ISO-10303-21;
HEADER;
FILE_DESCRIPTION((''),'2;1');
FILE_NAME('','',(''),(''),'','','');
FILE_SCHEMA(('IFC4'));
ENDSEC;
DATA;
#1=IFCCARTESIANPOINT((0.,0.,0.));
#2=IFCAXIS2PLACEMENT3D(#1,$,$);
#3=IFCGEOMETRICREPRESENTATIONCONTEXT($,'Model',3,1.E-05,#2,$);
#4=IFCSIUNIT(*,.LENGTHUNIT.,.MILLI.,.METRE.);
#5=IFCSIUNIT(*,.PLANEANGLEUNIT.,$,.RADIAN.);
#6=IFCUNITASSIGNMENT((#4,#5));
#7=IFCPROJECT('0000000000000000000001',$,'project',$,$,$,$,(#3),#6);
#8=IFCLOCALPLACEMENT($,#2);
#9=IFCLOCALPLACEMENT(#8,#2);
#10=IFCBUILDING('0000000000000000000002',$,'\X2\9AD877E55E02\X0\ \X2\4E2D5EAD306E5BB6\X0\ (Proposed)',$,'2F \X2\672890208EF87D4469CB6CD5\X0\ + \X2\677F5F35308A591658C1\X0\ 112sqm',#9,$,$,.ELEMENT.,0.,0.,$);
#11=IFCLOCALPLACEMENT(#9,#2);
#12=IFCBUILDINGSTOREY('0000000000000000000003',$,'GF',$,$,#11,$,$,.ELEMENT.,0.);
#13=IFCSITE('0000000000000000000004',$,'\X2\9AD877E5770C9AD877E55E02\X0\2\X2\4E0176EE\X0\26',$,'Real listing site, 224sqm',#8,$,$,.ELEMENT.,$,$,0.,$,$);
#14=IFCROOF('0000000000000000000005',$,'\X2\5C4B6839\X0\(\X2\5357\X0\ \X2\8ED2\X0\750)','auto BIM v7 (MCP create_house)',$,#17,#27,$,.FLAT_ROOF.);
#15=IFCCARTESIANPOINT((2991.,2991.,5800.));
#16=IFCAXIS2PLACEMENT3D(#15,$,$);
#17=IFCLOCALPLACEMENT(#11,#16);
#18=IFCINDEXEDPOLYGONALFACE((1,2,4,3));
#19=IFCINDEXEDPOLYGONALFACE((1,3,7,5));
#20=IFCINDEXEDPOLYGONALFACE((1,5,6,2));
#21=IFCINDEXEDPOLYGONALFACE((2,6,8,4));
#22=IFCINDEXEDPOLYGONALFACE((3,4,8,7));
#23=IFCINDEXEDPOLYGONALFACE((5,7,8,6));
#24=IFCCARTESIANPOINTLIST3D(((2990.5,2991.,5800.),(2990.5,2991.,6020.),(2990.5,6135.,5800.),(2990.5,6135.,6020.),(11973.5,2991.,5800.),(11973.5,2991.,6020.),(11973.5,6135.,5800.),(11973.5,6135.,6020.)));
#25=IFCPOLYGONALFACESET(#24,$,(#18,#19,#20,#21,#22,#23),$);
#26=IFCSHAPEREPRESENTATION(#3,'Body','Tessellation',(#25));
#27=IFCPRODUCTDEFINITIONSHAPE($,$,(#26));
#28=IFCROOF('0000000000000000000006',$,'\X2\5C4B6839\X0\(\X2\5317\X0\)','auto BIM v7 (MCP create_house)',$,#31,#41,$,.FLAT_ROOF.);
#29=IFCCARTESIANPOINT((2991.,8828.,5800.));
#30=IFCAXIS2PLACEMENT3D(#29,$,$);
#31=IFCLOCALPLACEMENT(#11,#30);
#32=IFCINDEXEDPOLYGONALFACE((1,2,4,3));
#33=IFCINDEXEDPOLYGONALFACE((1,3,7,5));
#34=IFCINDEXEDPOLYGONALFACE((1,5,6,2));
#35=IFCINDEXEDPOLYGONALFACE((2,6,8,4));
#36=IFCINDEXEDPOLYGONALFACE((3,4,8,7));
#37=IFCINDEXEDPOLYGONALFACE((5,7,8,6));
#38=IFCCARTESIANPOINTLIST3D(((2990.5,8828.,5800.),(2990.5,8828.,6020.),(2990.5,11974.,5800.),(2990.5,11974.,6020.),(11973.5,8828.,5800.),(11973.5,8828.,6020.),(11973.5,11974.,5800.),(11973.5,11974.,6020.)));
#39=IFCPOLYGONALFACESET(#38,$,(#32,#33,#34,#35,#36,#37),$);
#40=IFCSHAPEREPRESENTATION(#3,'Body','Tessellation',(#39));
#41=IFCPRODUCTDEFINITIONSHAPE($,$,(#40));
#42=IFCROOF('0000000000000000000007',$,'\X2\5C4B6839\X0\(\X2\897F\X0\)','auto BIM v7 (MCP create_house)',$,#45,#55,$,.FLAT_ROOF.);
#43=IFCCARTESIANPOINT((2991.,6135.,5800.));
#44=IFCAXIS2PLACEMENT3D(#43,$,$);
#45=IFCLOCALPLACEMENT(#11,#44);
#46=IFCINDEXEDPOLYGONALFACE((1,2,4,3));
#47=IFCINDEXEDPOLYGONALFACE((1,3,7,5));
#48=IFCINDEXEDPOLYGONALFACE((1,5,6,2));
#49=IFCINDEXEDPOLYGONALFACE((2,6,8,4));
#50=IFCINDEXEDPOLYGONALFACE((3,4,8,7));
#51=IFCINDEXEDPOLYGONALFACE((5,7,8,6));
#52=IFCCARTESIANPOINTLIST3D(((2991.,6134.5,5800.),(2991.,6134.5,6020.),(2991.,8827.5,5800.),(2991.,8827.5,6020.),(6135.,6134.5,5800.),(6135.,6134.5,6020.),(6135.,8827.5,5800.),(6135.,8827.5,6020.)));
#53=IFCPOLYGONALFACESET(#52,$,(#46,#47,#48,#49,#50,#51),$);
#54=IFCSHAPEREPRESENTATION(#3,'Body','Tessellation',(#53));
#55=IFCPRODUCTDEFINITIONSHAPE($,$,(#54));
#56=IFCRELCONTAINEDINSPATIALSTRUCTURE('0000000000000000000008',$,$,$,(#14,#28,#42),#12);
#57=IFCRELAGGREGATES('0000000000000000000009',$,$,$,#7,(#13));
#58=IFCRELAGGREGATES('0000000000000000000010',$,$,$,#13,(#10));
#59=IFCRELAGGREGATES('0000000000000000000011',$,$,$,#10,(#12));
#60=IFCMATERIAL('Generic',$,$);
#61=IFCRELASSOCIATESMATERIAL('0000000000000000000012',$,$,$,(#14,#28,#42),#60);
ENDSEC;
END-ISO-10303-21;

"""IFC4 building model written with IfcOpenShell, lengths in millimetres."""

from ifc_helpers import new_model, si_unit, frame, frame_2d, origin, place, context, project, spatial, rectangle, extrude, material, element, save


model = new_model("IFC4")

# Units and contexts
model_context = context("Model", 3, precision=1e-05, world=origin())
ifc_project = project(units=[si_unit("LENGTHUNIT", "METRE", prefix="MILLI"), si_unit("PLANEANGLEUNIT", "RADIAN")], contexts=[model_context])

# Site, building, storey
site_placement = place(None, origin())
site = spatial("IfcSite", under=ifc_project, at=site_placement, Name="高知県高知市2丁目26", ObjectType="Real listing site, 224sqm", CompositionType="ELEMENT", RefElevation=0.0)
building_placement = place(site_placement, origin())
building = spatial("IfcBuilding", under=site, at=building_placement, Name="高知市 中庭の家 (Proposed)", ObjectType="2F 木造軸組構法 + 板張り外壁 112sqm", CompositionType="ELEMENT", ElevationOfRefHeight=0.0, ElevationOfTerrain=0.0)
storey_placement = place(building_placement, origin())
storey = spatial("IfcBuildingStorey", under=building, at=storey_placement, Name="GF", CompositionType="ELEMENT", Elevation=0.0)

# Shared definitions
ifc_material = material(Name="Generic")

# Roofs
roof_1_placement = place(storey_placement, frame((2991.0, 2991.0, 5800.0)))
element("IfcRoof", 1, at=roof_1_placement, inside=storey, material=ifc_material, Name="屋根(南 軒750)", Description="auto BIM v7 (MCP create_house)", PredefinedType="FLAT_ROOF", context=model_context, shape_type="SweptSolid", body=[
    extrude(rectangle(XDim=8983.0, YDim=3144.0, at=frame_2d((4491.0, 1572.0))), frame((2991.0, 2991.0, 5800.0)), (0.0, 0.0, 1.0), 220.0),
])
roof_2_placement = place(storey_placement, frame((2991.0, 8828.0, 5800.0)))
element("IfcRoof", 2, at=roof_2_placement, inside=storey, material=ifc_material, Name="屋根(北)", Description="auto BIM v7 (MCP create_house)", PredefinedType="FLAT_ROOF", context=model_context, shape_type="SweptSolid", body=[
    extrude(rectangle(XDim=8983.0, YDim=3146.0, at=frame_2d((4491.0, 1573.0))), frame((2991.0, 8828.0, 5800.0)), (0.0, 0.0, 1.0), 220.0),
])
roof_3_placement = place(storey_placement, frame((2991.0, 6135.0, 5800.0)))
element("IfcRoof", 3, at=roof_3_placement, inside=storey, material=ifc_material, Name="屋根(西)", Description="auto BIM v7 (MCP create_house)", PredefinedType="FLAT_ROOF", context=model_context, shape_type="SweptSolid", body=[
    extrude(rectangle(XDim=3144.0, YDim=2693.0, at=frame_2d((1572.0, 1346.0))), frame((2991.0, 6135.0, 5800.0)), (0.0, 0.0, 1.0), 220.0),
])

save(model, "model.ifc")
